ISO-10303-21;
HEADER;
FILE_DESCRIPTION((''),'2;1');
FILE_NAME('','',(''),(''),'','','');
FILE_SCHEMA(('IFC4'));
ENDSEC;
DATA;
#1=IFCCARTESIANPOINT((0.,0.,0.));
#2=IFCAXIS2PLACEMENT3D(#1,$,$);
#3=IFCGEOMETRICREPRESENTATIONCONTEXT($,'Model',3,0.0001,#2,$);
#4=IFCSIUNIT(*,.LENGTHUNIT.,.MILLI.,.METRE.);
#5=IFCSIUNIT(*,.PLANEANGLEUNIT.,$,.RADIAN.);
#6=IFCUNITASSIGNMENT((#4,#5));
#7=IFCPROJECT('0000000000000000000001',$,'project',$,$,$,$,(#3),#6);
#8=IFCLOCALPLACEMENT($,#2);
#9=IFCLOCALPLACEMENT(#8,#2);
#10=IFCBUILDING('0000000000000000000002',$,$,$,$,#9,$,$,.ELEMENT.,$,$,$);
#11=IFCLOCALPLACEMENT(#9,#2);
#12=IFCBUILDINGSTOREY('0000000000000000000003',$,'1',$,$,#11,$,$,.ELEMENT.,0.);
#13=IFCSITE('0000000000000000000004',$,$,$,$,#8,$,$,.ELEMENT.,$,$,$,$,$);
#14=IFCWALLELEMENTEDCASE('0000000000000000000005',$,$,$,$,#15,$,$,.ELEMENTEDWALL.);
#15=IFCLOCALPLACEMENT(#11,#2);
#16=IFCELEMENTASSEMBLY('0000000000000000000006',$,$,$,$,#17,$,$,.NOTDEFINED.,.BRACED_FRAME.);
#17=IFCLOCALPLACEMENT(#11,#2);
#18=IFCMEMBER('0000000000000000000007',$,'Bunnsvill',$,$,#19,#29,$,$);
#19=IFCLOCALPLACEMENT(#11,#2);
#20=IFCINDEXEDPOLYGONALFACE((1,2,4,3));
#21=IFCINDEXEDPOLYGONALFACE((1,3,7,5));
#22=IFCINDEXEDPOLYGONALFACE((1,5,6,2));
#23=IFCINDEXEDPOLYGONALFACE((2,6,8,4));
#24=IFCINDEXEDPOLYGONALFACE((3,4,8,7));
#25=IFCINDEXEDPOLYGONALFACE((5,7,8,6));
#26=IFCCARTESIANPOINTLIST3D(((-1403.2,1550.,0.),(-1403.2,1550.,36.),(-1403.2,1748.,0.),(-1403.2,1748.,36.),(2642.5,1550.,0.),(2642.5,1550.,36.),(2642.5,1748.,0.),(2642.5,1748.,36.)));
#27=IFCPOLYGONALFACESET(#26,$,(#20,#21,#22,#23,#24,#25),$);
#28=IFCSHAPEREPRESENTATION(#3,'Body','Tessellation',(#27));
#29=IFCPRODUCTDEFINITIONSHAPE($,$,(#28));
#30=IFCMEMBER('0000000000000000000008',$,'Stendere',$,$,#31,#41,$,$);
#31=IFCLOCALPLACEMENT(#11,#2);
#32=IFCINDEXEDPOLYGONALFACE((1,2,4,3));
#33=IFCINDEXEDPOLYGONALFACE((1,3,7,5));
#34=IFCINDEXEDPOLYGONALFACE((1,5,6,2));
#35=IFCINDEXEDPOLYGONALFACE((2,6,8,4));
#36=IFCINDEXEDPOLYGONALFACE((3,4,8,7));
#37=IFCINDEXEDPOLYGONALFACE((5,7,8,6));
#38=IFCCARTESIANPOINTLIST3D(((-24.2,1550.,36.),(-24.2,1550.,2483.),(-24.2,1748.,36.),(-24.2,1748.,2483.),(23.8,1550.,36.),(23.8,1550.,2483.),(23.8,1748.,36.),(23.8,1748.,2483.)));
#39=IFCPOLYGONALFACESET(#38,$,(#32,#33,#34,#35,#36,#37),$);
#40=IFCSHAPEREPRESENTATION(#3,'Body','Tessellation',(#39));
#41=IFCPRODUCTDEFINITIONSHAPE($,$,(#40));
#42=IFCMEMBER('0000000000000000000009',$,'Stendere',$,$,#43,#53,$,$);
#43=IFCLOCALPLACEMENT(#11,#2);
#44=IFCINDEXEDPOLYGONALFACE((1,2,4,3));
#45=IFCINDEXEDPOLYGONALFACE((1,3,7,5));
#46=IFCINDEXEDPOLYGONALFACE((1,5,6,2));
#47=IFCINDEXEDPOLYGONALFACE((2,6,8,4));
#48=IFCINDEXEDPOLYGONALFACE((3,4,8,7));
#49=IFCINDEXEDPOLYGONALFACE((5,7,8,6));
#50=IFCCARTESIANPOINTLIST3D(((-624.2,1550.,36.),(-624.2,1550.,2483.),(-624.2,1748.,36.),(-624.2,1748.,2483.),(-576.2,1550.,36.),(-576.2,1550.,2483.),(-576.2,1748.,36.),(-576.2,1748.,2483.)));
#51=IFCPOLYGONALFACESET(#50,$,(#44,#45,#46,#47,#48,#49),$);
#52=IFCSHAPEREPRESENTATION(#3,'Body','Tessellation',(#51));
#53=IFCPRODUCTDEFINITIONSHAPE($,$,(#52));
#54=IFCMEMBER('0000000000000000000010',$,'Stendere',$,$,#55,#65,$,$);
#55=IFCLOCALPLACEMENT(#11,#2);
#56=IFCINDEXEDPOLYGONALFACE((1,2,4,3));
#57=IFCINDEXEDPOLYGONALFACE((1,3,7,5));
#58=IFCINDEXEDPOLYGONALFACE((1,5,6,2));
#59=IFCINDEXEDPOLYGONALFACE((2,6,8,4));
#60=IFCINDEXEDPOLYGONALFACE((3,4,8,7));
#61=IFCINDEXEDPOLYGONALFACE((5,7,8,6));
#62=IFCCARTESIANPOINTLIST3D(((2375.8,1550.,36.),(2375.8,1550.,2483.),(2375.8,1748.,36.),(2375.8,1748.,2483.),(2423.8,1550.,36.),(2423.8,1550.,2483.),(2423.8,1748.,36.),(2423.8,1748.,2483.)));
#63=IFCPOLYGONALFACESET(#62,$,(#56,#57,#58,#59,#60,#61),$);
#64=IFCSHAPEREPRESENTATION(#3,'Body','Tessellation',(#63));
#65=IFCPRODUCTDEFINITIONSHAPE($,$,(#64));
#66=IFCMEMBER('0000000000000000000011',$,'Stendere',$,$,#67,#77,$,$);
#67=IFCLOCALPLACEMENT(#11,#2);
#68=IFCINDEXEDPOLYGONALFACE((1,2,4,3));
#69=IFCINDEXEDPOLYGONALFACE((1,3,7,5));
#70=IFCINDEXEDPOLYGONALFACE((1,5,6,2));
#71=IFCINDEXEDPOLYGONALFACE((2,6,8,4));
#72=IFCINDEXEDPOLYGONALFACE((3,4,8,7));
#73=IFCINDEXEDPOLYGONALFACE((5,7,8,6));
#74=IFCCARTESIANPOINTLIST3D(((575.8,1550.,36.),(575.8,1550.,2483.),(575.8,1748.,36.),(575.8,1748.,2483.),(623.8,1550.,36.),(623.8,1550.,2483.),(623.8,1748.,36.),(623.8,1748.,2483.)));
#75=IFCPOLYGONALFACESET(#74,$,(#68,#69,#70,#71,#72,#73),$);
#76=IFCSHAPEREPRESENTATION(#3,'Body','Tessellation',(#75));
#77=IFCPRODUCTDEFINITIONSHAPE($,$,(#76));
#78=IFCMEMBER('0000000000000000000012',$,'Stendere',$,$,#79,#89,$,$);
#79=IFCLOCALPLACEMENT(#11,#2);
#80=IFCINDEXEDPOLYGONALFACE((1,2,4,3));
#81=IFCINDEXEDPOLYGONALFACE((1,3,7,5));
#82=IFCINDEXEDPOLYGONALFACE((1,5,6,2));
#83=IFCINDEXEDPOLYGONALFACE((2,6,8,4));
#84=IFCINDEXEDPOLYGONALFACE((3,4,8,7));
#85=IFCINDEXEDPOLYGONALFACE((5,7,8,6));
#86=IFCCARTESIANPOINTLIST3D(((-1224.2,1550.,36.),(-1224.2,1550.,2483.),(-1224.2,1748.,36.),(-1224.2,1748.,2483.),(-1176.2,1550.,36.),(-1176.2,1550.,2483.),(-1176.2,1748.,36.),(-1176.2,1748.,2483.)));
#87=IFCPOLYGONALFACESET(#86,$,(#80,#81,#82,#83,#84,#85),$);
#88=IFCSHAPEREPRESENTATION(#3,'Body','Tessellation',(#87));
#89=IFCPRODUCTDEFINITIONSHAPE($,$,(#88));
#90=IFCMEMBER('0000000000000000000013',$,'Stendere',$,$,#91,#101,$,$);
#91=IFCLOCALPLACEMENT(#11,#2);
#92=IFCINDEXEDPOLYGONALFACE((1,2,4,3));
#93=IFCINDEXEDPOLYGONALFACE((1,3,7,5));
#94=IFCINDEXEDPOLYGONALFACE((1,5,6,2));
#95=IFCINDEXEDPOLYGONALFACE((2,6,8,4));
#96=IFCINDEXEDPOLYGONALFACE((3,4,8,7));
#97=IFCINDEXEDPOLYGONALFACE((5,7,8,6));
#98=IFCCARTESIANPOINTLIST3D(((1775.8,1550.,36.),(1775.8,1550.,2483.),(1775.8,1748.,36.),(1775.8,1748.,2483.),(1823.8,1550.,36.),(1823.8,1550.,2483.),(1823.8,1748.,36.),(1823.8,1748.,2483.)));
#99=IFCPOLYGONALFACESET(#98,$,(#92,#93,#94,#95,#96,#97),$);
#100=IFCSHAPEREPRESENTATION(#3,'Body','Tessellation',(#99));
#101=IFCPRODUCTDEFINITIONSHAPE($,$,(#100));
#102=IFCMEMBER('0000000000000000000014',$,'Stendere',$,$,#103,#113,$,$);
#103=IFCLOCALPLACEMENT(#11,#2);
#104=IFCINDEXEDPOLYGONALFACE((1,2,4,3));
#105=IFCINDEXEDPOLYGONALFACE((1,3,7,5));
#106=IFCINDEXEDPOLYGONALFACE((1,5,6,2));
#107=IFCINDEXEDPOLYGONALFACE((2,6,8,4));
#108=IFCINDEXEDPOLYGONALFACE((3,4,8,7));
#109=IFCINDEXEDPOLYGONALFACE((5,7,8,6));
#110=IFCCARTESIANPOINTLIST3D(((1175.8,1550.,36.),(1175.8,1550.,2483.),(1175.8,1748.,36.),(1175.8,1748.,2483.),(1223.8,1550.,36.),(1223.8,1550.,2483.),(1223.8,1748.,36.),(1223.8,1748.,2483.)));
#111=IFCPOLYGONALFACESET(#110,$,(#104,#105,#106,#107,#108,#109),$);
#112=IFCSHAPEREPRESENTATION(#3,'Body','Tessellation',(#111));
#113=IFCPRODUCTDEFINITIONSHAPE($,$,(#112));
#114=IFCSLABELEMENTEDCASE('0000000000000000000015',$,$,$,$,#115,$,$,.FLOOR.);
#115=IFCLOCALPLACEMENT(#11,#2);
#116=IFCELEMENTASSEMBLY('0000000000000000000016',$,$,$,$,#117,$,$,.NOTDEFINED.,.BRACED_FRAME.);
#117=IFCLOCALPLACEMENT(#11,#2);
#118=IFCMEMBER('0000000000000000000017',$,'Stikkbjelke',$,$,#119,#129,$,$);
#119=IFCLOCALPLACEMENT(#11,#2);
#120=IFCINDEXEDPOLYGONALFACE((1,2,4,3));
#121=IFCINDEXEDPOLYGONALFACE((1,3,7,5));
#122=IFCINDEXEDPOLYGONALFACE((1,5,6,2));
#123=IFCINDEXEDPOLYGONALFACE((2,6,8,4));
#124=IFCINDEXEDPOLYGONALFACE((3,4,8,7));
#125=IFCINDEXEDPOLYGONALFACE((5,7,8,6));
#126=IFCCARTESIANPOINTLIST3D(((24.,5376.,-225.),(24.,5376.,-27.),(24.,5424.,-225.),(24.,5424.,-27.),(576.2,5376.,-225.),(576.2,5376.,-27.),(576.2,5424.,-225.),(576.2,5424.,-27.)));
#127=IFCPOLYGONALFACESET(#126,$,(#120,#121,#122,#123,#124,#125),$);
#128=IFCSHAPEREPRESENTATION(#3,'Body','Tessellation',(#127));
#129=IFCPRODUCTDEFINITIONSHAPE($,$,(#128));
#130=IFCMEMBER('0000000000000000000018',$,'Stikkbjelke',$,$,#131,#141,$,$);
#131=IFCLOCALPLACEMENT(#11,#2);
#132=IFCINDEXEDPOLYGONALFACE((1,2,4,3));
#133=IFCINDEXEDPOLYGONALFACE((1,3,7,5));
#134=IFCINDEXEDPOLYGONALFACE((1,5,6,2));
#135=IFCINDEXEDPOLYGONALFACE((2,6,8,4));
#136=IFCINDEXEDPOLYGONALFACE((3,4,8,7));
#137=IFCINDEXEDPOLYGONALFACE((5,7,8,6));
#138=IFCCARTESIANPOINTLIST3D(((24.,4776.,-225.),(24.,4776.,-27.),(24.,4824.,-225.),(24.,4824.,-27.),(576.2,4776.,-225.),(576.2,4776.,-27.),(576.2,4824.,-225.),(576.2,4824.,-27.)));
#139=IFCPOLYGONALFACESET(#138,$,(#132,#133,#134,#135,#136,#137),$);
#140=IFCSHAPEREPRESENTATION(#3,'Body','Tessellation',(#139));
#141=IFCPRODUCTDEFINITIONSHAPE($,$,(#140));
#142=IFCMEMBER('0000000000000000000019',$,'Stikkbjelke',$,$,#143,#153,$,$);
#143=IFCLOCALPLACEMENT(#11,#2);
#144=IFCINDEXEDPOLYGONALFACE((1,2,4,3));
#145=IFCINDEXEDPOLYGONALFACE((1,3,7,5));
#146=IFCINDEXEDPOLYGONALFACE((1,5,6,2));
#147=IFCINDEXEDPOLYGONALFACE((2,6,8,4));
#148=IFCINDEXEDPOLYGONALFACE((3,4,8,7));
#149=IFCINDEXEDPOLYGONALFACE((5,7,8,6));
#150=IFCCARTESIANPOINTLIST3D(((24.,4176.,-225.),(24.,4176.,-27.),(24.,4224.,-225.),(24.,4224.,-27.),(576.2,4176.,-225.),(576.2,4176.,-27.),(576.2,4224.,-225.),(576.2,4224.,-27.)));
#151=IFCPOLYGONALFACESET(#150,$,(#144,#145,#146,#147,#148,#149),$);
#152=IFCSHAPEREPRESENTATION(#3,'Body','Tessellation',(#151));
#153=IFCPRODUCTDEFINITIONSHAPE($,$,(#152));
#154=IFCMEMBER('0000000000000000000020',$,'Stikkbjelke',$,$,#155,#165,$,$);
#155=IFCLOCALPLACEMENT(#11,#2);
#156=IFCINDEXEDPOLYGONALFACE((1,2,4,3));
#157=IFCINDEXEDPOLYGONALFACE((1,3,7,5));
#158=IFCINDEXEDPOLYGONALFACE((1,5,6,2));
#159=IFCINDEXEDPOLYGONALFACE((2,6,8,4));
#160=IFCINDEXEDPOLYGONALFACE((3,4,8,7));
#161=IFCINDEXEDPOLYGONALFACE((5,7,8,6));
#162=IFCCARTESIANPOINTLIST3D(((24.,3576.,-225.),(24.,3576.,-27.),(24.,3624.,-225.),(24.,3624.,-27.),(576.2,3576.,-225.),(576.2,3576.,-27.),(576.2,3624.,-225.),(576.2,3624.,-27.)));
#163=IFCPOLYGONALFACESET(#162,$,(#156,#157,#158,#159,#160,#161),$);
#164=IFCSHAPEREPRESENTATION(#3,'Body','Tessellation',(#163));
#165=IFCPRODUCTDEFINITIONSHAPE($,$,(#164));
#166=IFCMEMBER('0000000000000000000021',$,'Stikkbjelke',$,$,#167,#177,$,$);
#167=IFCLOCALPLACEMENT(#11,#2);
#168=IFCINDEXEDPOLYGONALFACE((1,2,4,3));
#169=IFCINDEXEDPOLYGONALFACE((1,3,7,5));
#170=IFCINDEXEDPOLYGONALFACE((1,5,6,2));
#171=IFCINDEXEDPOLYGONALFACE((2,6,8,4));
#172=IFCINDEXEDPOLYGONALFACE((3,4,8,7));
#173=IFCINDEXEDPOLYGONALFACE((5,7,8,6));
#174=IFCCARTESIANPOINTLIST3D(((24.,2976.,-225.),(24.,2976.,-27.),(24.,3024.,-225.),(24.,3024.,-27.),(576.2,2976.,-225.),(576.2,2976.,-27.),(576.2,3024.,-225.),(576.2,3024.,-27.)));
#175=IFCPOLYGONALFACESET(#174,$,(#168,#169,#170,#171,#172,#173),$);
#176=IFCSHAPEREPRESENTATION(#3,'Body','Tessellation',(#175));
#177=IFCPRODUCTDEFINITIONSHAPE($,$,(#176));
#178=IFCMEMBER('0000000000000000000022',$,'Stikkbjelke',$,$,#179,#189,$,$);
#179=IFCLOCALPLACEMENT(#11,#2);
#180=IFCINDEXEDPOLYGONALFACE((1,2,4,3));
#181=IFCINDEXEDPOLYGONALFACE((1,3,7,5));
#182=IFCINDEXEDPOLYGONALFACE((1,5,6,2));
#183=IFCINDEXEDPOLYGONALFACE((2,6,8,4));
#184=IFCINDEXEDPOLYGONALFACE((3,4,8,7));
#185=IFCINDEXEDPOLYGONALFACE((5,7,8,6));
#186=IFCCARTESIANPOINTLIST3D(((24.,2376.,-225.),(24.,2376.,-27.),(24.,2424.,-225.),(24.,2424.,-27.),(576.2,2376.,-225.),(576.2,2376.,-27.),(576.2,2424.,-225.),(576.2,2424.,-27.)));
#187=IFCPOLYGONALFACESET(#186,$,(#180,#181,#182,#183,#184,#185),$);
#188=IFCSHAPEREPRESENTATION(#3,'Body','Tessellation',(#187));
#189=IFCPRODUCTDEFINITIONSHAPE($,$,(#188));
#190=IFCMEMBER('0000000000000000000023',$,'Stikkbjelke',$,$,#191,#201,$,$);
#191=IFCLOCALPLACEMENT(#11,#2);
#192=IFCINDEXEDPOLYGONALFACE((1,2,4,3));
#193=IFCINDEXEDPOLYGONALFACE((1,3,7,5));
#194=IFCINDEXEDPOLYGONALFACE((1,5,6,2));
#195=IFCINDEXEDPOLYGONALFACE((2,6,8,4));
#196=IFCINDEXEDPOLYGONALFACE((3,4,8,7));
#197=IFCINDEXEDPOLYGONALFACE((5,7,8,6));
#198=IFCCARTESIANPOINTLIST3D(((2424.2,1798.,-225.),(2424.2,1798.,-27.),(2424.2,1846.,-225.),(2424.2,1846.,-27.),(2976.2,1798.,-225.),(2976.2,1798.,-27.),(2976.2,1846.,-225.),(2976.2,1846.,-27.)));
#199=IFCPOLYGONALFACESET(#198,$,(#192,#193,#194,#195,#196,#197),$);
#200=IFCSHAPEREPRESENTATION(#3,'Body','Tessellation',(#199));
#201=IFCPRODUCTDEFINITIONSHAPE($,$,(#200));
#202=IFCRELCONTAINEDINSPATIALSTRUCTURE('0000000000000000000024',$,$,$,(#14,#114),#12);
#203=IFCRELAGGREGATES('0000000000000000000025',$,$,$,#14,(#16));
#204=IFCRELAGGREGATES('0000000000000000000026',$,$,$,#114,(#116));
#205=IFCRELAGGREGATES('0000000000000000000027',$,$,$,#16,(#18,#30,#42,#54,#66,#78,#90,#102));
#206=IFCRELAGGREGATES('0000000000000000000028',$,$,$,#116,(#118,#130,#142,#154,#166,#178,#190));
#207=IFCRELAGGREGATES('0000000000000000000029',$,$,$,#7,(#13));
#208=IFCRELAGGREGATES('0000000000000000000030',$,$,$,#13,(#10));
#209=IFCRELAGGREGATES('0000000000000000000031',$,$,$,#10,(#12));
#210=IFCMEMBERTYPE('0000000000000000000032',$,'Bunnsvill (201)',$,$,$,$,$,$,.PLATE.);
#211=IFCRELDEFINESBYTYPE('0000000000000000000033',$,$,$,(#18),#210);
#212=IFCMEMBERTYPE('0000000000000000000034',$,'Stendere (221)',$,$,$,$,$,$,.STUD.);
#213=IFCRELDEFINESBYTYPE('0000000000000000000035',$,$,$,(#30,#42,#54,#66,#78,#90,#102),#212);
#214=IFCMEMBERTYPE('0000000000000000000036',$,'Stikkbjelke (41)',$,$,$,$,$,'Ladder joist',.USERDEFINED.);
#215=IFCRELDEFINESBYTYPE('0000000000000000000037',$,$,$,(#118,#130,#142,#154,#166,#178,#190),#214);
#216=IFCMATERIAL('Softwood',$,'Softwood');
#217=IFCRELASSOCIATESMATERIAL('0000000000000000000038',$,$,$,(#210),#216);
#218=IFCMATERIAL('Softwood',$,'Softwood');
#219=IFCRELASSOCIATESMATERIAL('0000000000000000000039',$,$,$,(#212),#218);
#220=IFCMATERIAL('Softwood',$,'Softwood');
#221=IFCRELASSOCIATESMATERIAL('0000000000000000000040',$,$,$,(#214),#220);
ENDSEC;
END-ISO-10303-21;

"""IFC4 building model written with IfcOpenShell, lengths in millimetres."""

from ifc_helpers import new_model, si_unit, frame, origin, place, context, project, spatial, rectangle, extrude, material, material_profile, profile_set, type_object, element, aggregate, save


model = new_model("IFC4")

# Units and contexts
model_context = context("Model", 3, precision=0.0001, world=origin())
ifc_project = project(units=[si_unit("LENGTHUNIT", "METRE", prefix="MILLI"), si_unit("PLANEANGLEUNIT", "RADIAN")], contexts=[model_context])

# Site, building, storey
site_placement = place(None, origin())
site = spatial("IfcSite", under=ifc_project, at=site_placement, CompositionType="ELEMENT")
building_placement = place(site_placement, origin())
building = spatial("IfcBuilding", under=site, at=building_placement, CompositionType="ELEMENT")
storey_placement = place(building_placement, origin())
storey = spatial("IfcBuildingStorey", under=building, at=storey_placement, Name="1", CompositionType="ELEMENT", Elevation=0.0)

# Wall, element assembly, members
wall_placement = place(storey_placement, frame((-1403.2, 1748.0, 0.0), z_axis=(0.0, -1.0, 0.0)))
wall = element("IfcWallElementedCase", 1, at=wall_placement, inside=storey, PredefinedType="ELEMENTEDWALL")
assembly_1_placement = place(wall_placement, origin())
assembly_1 = element("IfcElementAssembly", 2, at=assembly_1_placement, AssemblyPlace="NOTDEFINED", PredefinedType="BRACED_FRAME")
aggregate(wall, [assembly_1])
ifc_material_1 = material(Name="Softwood", Category="Softwood")
ifc_material_profile_1 = material_profile(ifc_material_1, rectangle(XDim=36.0, YDim=198.0), Name="Bunnsvill (201)")
ifc_profile_set_1 = profile_set([ifc_material_profile_1])
member_type_1 = type_object("IfcMemberType", Name="Bunnsvill (201)", PredefinedType="PLATE", material=ifc_profile_set_1)
member_1_placement = place(assembly_1_placement, frame((0.0, 18.0, 0.0), z_axis=(1.0, 0.0, 0.0), x_axis=(0.0, 1.0, 0.0)))
member_1 = element("IfcMember", 3, at=member_1_placement, type_object=member_type_1, Name="Bunnsvill", context=model_context, shape_type="SweptSolid", body=[
    extrude(rectangle(XDim=36.0, YDim=198.0), frame((0.0, 99.0, 0.0)), (0.0, 0.0, 1.0), 4045.7),
])
ifc_material_2 = material(Name="Softwood", Category="Softwood")
ifc_material_profile_2 = material_profile(ifc_material_2, rectangle(XDim=48.0, YDim=198.0), Name="Stendere (221)")
ifc_profile_set_2 = profile_set([ifc_material_profile_2])
member_type_2 = type_object("IfcMemberType", Name="Stendere (221)", PredefinedType="STUD", material=ifc_profile_set_2)
member_2_placement = place(assembly_1_placement, frame((1403.0, 36.0, 0.0), z_axis=(0.0, 1.0, 0.0), x_axis=(-1.0, 0.0, 0.0)))
member_2 = element("IfcMember", 4, at=member_2_placement, type_object=member_type_2, Name="Stendere", context=model_context, shape_type="SweptSolid", body=[
    extrude(rectangle(XDim=48.0, YDim=198.0), frame((0.0, 99.0, 0.0)), (0.0, 0.0, 1.0), 2447.0),
])
member_3_placement = place(assembly_1_placement, frame((803.0, 36.0, 0.0), z_axis=(0.0, 1.0, 0.0), x_axis=(-1.0, 0.0, 0.0)))
member_3 = element("IfcMember", 5, at=member_3_placement, type_object=member_type_2, Name="Stendere", context=model_context, shape_type="SweptSolid", body=[
    extrude(rectangle(XDim=48.0, YDim=198.0), frame((0.0, 99.0, 0.0)), (0.0, 0.0, 1.0), 2447.0),
])
member_4_placement = place(assembly_1_placement, frame((3803.0, 36.0, 0.0), z_axis=(0.0, 1.0, 0.0), x_axis=(-1.0, 0.0, 0.0)))
member_4 = element("IfcMember", 6, at=member_4_placement, type_object=member_type_2, Name="Stendere", context=model_context, shape_type="SweptSolid", body=[
    extrude(rectangle(XDim=48.0, YDim=198.0), frame((0.0, 99.0, 0.0)), (0.0, 0.0, 1.0), 2447.0),
])
member_5_placement = place(assembly_1_placement, frame((2003.0, 36.0, 0.0), z_axis=(0.0, 1.0, 0.0), x_axis=(-1.0, 0.0, 0.0)))
member_5 = element("IfcMember", 7, at=member_5_placement, type_object=member_type_2, Name="Stendere", context=model_context, shape_type="SweptSolid", body=[
    extrude(rectangle(XDim=48.0, YDim=198.0), frame((0.0, 99.0, 0.0)), (0.0, 0.0, 1.0), 2447.0),
])
member_6_placement = place(assembly_1_placement, frame((203.0, 36.0, 0.0), z_axis=(0.0, 1.0, 0.0), x_axis=(-1.0, 0.0, 0.0)))
member_6 = element("IfcMember", 8, at=member_6_placement, type_object=member_type_2, Name="Stendere", context=model_context, shape_type="SweptSolid", body=[
    extrude(rectangle(XDim=48.0, YDim=198.0), frame((0.0, 99.0, 0.0)), (0.0, 0.0, 1.0), 2447.0),
])
member_7_placement = place(assembly_1_placement, frame((3203.0, 36.0, 0.0), z_axis=(0.0, 1.0, 0.0), x_axis=(-1.0, 0.0, 0.0)))
member_7 = element("IfcMember", 9, at=member_7_placement, type_object=member_type_2, Name="Stendere", context=model_context, shape_type="SweptSolid", body=[
    extrude(rectangle(XDim=48.0, YDim=198.0), frame((0.0, 99.0, 0.0)), (0.0, 0.0, 1.0), 2447.0),
])
member_8_placement = place(assembly_1_placement, frame((2603.0, 36.0, 0.0), z_axis=(0.0, 1.0, 0.0), x_axis=(-1.0, 0.0, 0.0)))
member_8 = element("IfcMember", 10, at=member_8_placement, type_object=member_type_2, Name="Stendere", context=model_context, shape_type="SweptSolid", body=[
    extrude(rectangle(XDim=48.0, YDim=198.0), frame((0.0, 99.0, 0.0)), (0.0, 0.0, 1.0), 2447.0),
])

# Slab, element assembly, members
slab_placement = place(storey_placement, origin())
slab = element("IfcSlabElementedCase", 11, at=slab_placement, inside=storey, PredefinedType="FLOOR")
assembly_2_placement = place(slab_placement, frame((0.0, 0.0, -225.0)))
assembly_2 = element("IfcElementAssembly", 12, at=assembly_2_placement, AssemblyPlace="NOTDEFINED", PredefinedType="BRACED_FRAME")
aggregate(slab, [assembly_2])
ifc_material_3 = material(Name="Softwood", Category="Softwood")
ifc_material_profile_3 = material_profile(ifc_material_3, rectangle(XDim=48.0, YDim=198.0), Name="Stikkbjelke (41)")
ifc_profile_set_3 = profile_set([ifc_material_profile_3])
member_type_3 = type_object("IfcMemberType", Name="Stikkbjelke (41)", ElementType="Ladder joist", PredefinedType="USERDEFINED", material=ifc_profile_set_3)
member_9_placement = place(assembly_2_placement, frame((24.0, 5400.0, 0.0), z_axis=(1.0, 0.0, 0.0), x_axis=(0.0, 1.0, 0.0)))
member_9 = element("IfcMember", 13, at=member_9_placement, type_object=member_type_3, Name="Stikkbjelke", context=model_context, shape_type="SweptSolid", body=[
    extrude(rectangle(XDim=48.0, YDim=198.0), frame((0.0, 99.0, 0.0)), (0.0, 0.0, 1.0), 552.2),
])
member_10_placement = place(assembly_2_placement, frame((24.0, 4800.0, 0.0), z_axis=(1.0, 0.0, 0.0), x_axis=(0.0, 1.0, 0.0)))
member_10 = element("IfcMember", 14, at=member_10_placement, type_object=member_type_3, Name="Stikkbjelke", context=model_context, shape_type="SweptSolid", body=[
    extrude(rectangle(XDim=48.0, YDim=198.0), frame((0.0, 99.0, 0.0)), (0.0, 0.0, 1.0), 552.2),
])
member_11_placement = place(assembly_2_placement, frame((24.0, 4200.0, 0.0), z_axis=(1.0, 0.0, 0.0), x_axis=(0.0, 1.0, 0.0)))
member_11 = element("IfcMember", 15, at=member_11_placement, type_object=member_type_3, Name="Stikkbjelke", context=model_context, shape_type="SweptSolid", body=[
    extrude(rectangle(XDim=48.0, YDim=198.0), frame((0.0, 99.0, 0.0)), (0.0, 0.0, 1.0), 552.2),
])
member_12_placement = place(assembly_2_placement, frame((24.0, 3600.0, 0.0), z_axis=(1.0, 0.0, 0.0), x_axis=(0.0, 1.0, 0.0)))
member_12 = element("IfcMember", 16, at=member_12_placement, type_object=member_type_3, Name="Stikkbjelke", context=model_context, shape_type="SweptSolid", body=[
    extrude(rectangle(XDim=48.0, YDim=198.0), frame((0.0, 99.0, 0.0)), (0.0, 0.0, 1.0), 552.2),
])
member_13_placement = place(assembly_2_placement, frame((24.0, 3000.0, 0.0), z_axis=(1.0, 0.0, 0.0), x_axis=(0.0, 1.0, 0.0)))
member_13 = element("IfcMember", 17, at=member_13_placement, type_object=member_type_3, Name="Stikkbjelke", context=model_context, shape_type="SweptSolid", body=[
    extrude(rectangle(XDim=48.0, YDim=198.0), frame((0.0, 99.0, 0.0)), (0.0, 0.0, 1.0), 552.2),
])
member_14_placement = place(assembly_2_placement, frame((24.0, 2400.0, 0.0), z_axis=(1.0, 0.0, 0.0), x_axis=(0.0, 1.0, 0.0)))
member_14 = element("IfcMember", 18, at=member_14_placement, type_object=member_type_3, Name="Stikkbjelke", context=model_context, shape_type="SweptSolid", body=[
    extrude(rectangle(XDim=48.0, YDim=198.0), frame((0.0, 99.0, 0.0)), (0.0, 0.0, 1.0), 552.2),
])
member_15_placement = place(assembly_2_placement, frame((2424.2, 1822.0, 0.0), z_axis=(1.0, 0.0, 0.0), x_axis=(0.0, 1.0, 0.0)))
member_15 = element("IfcMember", 19, at=member_15_placement, type_object=member_type_3, Name="Stikkbjelke", context=model_context, shape_type="SweptSolid", body=[
    extrude(rectangle(XDim=48.0, YDim=198.0), frame((0.0, 99.0, 0.0)), (0.0, 0.0, 1.0), 552.0),
])

aggregate(assembly_1, [member_1, member_2, member_3, member_4, member_5, member_6, member_7, member_8])

aggregate(assembly_2, [member_9, member_10, member_11, member_12, member_13, member_14, member_15])

save(model, "model.ifc")
